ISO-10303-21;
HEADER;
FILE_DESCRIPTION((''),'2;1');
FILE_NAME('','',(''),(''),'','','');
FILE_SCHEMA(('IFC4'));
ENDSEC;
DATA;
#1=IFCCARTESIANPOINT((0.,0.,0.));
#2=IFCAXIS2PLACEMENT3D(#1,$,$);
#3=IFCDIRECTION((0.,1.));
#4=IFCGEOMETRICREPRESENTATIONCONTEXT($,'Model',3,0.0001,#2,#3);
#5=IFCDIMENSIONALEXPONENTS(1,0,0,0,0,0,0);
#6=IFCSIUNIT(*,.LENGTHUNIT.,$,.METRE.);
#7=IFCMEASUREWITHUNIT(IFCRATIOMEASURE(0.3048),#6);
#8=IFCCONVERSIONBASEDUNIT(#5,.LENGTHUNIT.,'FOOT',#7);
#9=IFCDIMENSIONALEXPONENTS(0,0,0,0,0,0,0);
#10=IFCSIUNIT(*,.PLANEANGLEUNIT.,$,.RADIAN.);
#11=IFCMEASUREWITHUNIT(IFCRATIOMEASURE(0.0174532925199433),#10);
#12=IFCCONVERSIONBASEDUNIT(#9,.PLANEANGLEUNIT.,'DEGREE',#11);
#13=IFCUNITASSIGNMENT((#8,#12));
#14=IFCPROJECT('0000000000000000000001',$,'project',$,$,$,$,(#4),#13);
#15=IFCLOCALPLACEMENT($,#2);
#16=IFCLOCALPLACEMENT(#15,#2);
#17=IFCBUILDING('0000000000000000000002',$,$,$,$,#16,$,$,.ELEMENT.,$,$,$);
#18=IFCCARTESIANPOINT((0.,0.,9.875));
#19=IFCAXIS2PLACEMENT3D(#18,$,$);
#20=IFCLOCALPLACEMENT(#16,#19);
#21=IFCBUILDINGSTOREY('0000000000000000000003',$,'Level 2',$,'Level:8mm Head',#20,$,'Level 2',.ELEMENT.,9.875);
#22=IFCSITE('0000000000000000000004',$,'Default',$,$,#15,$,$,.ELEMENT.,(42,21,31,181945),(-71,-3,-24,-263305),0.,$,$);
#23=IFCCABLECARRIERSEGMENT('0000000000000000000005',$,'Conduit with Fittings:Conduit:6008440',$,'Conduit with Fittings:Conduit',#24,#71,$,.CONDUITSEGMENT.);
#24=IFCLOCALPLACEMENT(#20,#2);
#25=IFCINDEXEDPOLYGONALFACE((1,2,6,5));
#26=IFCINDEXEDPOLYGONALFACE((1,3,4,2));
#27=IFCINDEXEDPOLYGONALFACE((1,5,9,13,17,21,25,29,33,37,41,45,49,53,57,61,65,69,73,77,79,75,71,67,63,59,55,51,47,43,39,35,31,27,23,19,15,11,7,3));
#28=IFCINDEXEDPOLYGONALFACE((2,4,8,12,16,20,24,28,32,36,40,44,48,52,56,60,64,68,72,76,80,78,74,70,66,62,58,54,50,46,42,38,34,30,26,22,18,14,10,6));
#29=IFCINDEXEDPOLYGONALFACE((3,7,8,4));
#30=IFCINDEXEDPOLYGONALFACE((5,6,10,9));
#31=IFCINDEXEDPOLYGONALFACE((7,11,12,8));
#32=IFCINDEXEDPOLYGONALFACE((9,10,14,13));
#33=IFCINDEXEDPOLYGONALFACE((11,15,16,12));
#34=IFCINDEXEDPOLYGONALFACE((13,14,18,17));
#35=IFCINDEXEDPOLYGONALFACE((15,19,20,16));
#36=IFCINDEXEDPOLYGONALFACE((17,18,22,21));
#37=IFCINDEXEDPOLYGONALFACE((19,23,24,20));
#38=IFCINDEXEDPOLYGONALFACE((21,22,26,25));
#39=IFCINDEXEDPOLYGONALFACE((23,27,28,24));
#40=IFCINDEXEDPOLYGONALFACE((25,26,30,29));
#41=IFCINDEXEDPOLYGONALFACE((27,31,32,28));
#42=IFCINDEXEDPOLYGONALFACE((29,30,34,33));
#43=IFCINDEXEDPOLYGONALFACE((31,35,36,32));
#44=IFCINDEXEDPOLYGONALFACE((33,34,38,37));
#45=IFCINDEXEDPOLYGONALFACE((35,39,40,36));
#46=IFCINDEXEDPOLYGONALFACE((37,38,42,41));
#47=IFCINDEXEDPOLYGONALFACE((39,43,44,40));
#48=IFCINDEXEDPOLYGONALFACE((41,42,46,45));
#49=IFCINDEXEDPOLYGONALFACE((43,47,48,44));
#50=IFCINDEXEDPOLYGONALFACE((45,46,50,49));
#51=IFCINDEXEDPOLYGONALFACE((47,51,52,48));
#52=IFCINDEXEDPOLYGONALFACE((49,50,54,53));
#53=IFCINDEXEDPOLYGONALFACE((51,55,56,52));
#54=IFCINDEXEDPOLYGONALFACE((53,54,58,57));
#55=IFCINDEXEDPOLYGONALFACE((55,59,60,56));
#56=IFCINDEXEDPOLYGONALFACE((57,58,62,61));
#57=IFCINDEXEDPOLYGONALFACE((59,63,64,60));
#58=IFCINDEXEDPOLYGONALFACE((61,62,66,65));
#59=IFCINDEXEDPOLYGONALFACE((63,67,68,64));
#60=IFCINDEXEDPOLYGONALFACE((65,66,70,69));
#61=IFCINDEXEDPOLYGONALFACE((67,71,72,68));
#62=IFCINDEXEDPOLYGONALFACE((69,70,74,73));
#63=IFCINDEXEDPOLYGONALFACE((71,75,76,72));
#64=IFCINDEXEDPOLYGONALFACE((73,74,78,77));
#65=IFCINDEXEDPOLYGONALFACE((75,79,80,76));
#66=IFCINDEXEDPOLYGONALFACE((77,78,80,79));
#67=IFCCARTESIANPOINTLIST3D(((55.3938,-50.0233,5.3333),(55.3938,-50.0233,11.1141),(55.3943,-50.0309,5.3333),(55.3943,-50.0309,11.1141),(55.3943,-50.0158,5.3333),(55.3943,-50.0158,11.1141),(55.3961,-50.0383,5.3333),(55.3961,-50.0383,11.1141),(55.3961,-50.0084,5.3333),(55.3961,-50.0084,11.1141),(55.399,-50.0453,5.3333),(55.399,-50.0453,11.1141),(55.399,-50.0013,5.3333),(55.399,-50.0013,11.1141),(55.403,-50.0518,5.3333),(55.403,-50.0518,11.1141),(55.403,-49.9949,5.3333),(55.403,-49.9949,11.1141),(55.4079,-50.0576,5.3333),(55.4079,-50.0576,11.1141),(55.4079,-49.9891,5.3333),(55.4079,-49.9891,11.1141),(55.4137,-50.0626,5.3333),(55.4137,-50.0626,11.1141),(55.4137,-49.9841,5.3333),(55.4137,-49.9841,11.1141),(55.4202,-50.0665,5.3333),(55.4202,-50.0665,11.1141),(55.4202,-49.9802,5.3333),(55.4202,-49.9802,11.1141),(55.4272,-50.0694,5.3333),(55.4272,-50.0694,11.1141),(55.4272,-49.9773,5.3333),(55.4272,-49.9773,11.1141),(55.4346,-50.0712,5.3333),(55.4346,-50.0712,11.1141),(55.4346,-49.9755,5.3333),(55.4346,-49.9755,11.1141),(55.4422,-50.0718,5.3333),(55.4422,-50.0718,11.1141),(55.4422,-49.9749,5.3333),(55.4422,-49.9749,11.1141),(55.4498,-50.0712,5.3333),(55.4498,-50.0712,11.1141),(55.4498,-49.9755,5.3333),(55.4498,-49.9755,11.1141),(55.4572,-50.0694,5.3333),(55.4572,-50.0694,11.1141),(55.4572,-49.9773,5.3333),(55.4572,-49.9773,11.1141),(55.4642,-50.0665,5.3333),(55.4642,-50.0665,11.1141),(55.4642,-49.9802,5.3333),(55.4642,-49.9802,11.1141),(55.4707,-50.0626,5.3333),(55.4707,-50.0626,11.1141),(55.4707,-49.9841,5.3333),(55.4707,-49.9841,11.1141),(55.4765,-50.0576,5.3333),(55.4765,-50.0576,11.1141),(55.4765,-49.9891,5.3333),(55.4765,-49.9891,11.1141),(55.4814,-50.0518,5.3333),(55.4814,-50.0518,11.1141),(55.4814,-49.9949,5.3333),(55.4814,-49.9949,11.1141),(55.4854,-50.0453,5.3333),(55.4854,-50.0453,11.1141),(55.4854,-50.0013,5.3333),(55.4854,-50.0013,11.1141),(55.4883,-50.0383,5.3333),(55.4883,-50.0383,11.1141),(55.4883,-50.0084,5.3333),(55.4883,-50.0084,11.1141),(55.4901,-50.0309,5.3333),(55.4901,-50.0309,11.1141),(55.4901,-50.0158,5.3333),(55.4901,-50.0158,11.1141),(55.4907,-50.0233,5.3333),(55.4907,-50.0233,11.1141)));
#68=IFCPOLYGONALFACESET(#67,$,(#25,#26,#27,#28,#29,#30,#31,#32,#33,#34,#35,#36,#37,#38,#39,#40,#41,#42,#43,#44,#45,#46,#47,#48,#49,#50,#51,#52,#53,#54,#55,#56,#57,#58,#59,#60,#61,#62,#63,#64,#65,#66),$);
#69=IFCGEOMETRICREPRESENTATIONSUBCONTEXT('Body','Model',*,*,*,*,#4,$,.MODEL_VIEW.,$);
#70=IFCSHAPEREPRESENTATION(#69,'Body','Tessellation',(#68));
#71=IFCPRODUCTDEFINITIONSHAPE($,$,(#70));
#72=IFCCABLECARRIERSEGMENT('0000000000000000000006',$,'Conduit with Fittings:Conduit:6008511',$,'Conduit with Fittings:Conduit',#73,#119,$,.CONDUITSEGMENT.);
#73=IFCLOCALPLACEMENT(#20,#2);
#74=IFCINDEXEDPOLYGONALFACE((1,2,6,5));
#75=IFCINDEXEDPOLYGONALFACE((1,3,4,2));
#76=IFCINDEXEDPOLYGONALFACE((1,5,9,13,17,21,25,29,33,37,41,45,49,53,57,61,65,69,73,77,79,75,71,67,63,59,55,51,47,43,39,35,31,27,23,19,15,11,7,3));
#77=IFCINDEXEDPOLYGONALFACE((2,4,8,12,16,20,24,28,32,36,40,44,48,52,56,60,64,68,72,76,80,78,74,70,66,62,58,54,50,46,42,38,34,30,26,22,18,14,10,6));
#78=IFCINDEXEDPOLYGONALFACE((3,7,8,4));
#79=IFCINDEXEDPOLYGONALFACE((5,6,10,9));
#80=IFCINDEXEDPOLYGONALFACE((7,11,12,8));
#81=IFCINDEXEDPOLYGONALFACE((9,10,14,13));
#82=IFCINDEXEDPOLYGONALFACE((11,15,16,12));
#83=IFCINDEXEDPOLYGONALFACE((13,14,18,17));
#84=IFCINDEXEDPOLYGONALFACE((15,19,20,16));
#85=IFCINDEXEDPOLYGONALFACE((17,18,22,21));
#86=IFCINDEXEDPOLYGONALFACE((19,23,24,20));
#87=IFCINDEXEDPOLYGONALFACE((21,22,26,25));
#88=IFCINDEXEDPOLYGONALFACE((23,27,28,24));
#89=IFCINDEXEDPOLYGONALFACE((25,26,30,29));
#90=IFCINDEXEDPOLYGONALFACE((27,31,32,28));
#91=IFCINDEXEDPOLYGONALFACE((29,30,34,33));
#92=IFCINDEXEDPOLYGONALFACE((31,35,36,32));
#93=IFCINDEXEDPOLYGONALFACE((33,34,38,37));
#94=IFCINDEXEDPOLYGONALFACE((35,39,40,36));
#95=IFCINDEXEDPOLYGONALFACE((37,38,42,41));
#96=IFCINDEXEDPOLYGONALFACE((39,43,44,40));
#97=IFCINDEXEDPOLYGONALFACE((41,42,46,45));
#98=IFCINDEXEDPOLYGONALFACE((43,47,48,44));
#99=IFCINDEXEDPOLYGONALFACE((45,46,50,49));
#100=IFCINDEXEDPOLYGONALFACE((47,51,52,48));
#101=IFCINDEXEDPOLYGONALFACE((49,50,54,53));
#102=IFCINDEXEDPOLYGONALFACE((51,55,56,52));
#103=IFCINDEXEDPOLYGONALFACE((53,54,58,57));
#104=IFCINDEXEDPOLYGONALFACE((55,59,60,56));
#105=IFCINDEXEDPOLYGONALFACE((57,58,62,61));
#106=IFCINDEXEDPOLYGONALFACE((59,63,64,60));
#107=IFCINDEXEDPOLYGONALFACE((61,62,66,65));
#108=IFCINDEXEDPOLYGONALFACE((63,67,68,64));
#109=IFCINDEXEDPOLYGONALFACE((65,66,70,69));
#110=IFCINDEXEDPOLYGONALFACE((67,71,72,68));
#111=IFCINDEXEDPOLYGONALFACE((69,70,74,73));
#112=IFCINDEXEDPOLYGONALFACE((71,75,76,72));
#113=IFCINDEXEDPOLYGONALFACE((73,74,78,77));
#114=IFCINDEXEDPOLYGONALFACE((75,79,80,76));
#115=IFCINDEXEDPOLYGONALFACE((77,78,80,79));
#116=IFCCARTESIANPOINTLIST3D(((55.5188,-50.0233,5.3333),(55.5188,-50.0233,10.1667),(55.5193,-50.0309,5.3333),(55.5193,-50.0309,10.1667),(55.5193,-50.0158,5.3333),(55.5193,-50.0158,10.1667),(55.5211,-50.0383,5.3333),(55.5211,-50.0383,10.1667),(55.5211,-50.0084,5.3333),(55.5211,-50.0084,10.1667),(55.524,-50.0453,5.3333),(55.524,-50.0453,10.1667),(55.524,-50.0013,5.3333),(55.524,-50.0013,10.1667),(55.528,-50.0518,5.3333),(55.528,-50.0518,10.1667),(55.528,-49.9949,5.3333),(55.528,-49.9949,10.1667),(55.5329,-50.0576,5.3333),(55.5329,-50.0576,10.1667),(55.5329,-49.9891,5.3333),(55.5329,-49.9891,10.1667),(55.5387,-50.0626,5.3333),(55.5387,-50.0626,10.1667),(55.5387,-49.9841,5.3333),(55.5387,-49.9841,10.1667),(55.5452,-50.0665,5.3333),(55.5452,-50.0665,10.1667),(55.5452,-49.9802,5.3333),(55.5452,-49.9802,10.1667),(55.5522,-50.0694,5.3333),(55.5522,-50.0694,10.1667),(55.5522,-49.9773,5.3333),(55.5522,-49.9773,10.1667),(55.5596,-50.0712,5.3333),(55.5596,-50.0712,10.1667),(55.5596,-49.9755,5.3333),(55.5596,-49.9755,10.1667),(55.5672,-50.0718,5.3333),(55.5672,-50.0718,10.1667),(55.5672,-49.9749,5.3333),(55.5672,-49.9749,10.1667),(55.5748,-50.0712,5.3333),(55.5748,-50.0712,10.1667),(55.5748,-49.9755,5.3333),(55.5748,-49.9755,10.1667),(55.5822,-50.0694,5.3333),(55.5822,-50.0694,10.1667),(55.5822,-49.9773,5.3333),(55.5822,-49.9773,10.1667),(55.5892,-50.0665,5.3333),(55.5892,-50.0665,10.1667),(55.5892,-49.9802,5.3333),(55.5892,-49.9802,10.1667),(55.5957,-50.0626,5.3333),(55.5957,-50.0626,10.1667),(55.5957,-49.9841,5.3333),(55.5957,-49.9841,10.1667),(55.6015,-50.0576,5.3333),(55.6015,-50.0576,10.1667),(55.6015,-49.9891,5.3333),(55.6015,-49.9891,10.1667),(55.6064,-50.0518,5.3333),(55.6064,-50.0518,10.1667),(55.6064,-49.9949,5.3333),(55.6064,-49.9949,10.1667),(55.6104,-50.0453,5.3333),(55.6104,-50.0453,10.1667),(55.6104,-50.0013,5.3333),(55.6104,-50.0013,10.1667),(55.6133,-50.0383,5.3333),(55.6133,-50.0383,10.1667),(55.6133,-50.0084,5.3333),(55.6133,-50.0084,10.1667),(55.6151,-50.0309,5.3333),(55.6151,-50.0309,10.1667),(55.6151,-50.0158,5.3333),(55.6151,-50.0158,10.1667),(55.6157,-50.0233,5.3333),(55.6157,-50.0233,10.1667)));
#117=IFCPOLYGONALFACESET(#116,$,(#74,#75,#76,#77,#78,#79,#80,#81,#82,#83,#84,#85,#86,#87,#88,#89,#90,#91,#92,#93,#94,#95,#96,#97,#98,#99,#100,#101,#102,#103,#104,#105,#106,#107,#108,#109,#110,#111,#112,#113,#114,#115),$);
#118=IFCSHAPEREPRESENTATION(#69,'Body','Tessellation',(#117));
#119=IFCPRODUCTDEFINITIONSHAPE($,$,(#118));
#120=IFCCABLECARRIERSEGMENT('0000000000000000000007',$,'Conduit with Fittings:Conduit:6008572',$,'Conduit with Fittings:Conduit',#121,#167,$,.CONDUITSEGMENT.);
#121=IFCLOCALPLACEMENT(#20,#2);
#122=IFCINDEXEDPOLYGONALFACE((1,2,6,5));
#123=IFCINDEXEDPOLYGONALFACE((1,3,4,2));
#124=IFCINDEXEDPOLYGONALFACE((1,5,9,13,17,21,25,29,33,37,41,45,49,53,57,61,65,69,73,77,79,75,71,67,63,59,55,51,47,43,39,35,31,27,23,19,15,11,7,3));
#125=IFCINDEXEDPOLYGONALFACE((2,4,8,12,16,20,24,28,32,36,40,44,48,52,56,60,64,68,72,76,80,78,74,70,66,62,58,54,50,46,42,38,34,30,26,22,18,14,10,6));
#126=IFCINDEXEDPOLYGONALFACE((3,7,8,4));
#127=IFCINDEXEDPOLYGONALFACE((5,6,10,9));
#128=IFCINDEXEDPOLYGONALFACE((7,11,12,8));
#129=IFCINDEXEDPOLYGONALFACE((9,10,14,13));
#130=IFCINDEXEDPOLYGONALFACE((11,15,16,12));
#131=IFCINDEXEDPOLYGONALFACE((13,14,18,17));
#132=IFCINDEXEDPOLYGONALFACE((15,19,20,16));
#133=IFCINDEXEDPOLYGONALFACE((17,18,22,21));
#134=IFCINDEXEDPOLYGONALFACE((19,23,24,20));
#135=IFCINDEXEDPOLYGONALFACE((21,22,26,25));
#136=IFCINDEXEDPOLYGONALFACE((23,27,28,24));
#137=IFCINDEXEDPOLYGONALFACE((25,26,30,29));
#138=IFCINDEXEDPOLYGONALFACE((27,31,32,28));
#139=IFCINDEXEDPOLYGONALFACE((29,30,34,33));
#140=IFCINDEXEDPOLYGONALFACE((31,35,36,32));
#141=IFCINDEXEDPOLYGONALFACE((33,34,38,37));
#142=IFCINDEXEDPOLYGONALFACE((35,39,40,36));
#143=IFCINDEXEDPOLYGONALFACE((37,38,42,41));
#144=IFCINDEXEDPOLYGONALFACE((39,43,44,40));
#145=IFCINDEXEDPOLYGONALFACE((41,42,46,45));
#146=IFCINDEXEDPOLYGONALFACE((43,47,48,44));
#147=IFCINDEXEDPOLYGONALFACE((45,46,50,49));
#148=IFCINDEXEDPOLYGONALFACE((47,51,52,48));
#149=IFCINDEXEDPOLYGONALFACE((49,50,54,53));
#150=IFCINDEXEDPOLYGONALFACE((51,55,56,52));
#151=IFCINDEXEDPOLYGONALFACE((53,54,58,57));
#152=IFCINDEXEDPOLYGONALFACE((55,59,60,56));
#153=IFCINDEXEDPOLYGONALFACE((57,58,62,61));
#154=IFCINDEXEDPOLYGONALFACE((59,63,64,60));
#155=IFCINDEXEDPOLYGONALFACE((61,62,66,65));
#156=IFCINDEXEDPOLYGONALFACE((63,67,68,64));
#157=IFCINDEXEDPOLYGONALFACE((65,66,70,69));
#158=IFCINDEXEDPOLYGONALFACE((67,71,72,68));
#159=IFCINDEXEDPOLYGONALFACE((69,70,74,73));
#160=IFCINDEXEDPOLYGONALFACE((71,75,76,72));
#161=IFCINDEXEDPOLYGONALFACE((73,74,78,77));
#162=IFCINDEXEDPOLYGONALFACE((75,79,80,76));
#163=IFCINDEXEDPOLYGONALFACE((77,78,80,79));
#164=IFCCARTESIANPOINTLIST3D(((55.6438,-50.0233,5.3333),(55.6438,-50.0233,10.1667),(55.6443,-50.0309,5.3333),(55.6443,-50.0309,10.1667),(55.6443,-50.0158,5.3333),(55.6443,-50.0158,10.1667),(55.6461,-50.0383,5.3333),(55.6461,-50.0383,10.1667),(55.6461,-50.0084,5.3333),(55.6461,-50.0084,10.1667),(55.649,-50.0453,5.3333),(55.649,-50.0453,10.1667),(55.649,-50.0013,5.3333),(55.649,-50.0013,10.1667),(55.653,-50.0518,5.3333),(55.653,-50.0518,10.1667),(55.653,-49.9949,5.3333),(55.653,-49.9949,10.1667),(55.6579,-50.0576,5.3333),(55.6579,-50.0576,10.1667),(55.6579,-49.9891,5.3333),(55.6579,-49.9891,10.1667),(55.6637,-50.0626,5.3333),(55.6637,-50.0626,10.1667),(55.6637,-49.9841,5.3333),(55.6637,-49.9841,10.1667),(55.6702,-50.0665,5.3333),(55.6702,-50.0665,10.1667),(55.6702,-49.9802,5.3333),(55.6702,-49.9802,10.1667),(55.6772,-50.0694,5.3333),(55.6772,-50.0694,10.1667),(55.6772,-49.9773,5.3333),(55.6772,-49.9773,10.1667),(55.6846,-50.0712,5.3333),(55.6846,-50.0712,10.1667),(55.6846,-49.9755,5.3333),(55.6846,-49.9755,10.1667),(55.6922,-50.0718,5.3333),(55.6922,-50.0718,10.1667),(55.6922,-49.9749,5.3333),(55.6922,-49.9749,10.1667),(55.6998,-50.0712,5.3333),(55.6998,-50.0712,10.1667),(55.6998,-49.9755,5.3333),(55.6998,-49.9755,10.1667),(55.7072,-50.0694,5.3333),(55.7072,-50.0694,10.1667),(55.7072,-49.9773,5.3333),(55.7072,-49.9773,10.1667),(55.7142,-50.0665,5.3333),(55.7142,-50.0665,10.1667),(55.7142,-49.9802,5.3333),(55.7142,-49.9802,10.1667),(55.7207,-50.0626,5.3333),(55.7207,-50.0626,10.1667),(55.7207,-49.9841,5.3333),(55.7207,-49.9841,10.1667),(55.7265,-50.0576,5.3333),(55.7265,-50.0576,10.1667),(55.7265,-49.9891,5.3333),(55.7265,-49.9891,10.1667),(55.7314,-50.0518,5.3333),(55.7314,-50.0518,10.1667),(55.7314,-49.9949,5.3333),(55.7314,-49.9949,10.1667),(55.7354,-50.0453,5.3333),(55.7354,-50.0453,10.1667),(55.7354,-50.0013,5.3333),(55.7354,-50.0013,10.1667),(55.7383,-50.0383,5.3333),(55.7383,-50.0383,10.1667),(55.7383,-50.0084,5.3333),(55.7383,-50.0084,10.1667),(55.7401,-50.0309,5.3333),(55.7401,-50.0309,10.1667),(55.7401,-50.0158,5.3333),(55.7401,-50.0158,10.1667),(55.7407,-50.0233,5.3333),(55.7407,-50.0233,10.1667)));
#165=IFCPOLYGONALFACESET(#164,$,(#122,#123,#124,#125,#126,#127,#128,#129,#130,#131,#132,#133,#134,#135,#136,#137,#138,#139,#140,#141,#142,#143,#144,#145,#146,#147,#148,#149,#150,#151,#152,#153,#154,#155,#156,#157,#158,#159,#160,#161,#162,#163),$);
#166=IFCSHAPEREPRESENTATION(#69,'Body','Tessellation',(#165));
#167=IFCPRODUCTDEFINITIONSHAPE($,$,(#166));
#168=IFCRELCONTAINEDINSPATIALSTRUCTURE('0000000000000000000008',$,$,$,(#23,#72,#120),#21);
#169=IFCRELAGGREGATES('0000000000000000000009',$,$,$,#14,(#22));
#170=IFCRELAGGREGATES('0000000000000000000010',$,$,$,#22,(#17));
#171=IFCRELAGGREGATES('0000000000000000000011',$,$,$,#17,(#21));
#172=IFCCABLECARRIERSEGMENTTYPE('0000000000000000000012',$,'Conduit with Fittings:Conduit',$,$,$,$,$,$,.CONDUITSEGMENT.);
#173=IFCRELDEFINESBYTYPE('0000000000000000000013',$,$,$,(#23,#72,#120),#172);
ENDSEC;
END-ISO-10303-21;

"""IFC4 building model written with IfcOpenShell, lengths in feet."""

from ifc_helpers import new_model, entity, si_unit, converted_unit, direction, frame, origin, place, context, subcontext, project, spatial, indexed_curve, outline, extrude, type_object, element, save


model = new_model("IFC4")

# Units and contexts
model_context = context("Model", 3, precision=0.0001, world=origin(), true_north=direction((0.0, 1.0)))
body_context = subcontext(model_context, "Body", "Model", "MODEL_VIEW")
ifc_project = project(units=[converted_unit("LENGTHUNIT", "FOOT", entity("IfcRatioMeasure", 0.3048), si_unit("LENGTHUNIT", "METRE"), dimensions=[1, 0, 0, 0, 0, 0, 0]), converted_unit("PLANEANGLEUNIT", "DEGREE", entity("IfcRatioMeasure", 0.0174532925199433), si_unit("PLANEANGLEUNIT", "RADIAN"), dimensions=[0, 0, 0, 0, 0, 0, 0])], contexts=[model_context])

# Site, building, storey
site_placement = place(None, origin())
site = spatial("IfcSite", under=ifc_project, at=site_placement, Name="Default", CompositionType="ELEMENT", RefLatitude=(42, 21, 31, 181945), RefLongitude=(-71, -3, -24, -263305), RefElevation=0.0)
building_placement = place(site_placement, origin())
building = spatial("IfcBuilding", under=site, at=building_placement, CompositionType="ELEMENT")
storey_placement = place(building_placement, frame((0.0, 0.0, 9.875)))
storey = spatial("IfcBuildingStorey", under=building, at=storey_placement, Name="Level 2", ObjectType="Level:8mm Head", LongName="Level 2", CompositionType="ELEMENT", Elevation=9.875)

# Cable carrier segments
cable_carrier_segment_type = type_object("IfcCableCarrierSegmentType", Name="Conduit with Fittings:Conduit", PredefinedType="CONDUITSEGMENT")
cable_carrier_segment_1_placement = place(storey_placement, origin())
element("IfcCableCarrierSegment", 1, at=cable_carrier_segment_1_placement, inside=storey, type_object=cable_carrier_segment_type, Name="Conduit with Fittings:Conduit:6008440", ObjectType="Conduit with Fittings:Conduit", PredefinedType="CONDUITSEGMENT", context=body_context, shape_type="SweptSolid", body=[
    extrude(outline(indexed_curve([(0.0485, 0.0), (0.0479, 0.0076), (0.0461, 0.015), (0.0432, 0.022), (0.0392, 0.0285), (0.0343, 0.0343), (0.0285, 0.0392), (0.022, 0.0432), (0.015, 0.0461), (0.0076, 0.0479), (0.0, 0.0485), (-0.0076, 0.0479), (-0.015, 0.0461), (-0.022, 0.0432), (-0.0285, 0.0392), (-0.0343, 0.0343), (-0.0392, 0.0285), (-0.0432, 0.022), (-0.0461, 0.015), (-0.0479, 0.0076), (-0.0485, 0.0), (-0.0479, -0.0076), (-0.0461, -0.015), (-0.0432, -0.022), (-0.0392, -0.0285), (-0.0343, -0.0343), (-0.0285, -0.0392), (-0.022, -0.0432), (-0.015, -0.0461), (-0.0076, -0.0479), (0.0, -0.0485), (0.0076, -0.0479), (0.015, -0.0461), (0.022, -0.0432), (0.0285, -0.0392), (0.0343, -0.0343), (0.0392, -0.0285), (0.0432, -0.022), (0.0461, -0.015), (0.0479, -0.0076), (0.0485, 0.0)], self_intersect=False)), frame((55.4422, -50.0233, 5.3333), z_axis=(0.0, 0.0, 1.0), x_axis=(-1.0, 0.0, 0.0)), (0.0, 0.0, 1.0), 5.7808),
])
cable_carrier_segment_2_placement = place(storey_placement, origin())
element("IfcCableCarrierSegment", 2, at=cable_carrier_segment_2_placement, inside=storey, type_object=cable_carrier_segment_type, Name="Conduit with Fittings:Conduit:6008511", ObjectType="Conduit with Fittings:Conduit", PredefinedType="CONDUITSEGMENT", context=body_context, shape_type="SweptSolid", body=[
    extrude(outline(indexed_curve([(0.0485, 0.0), (0.0479, 0.0076), (0.0461, 0.015), (0.0432, 0.022), (0.0392, 0.0285), (0.0343, 0.0343), (0.0285, 0.0392), (0.022, 0.0432), (0.015, 0.0461), (0.0076, 0.0479), (0.0, 0.0485), (-0.0076, 0.0479), (-0.015, 0.0461), (-0.022, 0.0432), (-0.0285, 0.0392), (-0.0343, 0.0343), (-0.0392, 0.0285), (-0.0432, 0.022), (-0.0461, 0.015), (-0.0479, 0.0076), (-0.0485, 0.0), (-0.0479, -0.0076), (-0.0461, -0.015), (-0.0432, -0.022), (-0.0392, -0.0285), (-0.0343, -0.0343), (-0.0285, -0.0392), (-0.022, -0.0432), (-0.015, -0.0461), (-0.0076, -0.0479), (0.0, -0.0485), (0.0076, -0.0479), (0.015, -0.0461), (0.022, -0.0432), (0.0285, -0.0392), (0.0343, -0.0343), (0.0392, -0.0285), (0.0432, -0.022), (0.0461, -0.015), (0.0479, -0.0076), (0.0485, 0.0)], self_intersect=False)), frame((55.5672, -50.0233, 5.3333), z_axis=(0.0, 0.0, 1.0), x_axis=(-1.0, 0.0, 0.0)), (0.0, 0.0, 1.0), 4.8333),
])
cable_carrier_segment_3_placement = place(storey_placement, origin())
element("IfcCableCarrierSegment", 3, at=cable_carrier_segment_3_placement, inside=storey, type_object=cable_carrier_segment_type, Name="Conduit with Fittings:Conduit:6008572", ObjectType="Conduit with Fittings:Conduit", PredefinedType="CONDUITSEGMENT", context=body_context, shape_type="SweptSolid", body=[
    extrude(outline(indexed_curve([(0.0485, 0.0), (0.0479, 0.0076), (0.0461, 0.015), (0.0432, 0.022), (0.0392, 0.0285), (0.0343, 0.0343), (0.0285, 0.0392), (0.022, 0.0432), (0.015, 0.0461), (0.0076, 0.0479), (0.0, 0.0485), (-0.0076, 0.0479), (-0.015, 0.0461), (-0.022, 0.0432), (-0.0285, 0.0392), (-0.0343, 0.0343), (-0.0392, 0.0285), (-0.0432, 0.022), (-0.0461, 0.015), (-0.0479, 0.0076), (-0.0485, 0.0), (-0.0479, -0.0076), (-0.0461, -0.015), (-0.0432, -0.022), (-0.0392, -0.0285), (-0.0343, -0.0343), (-0.0285, -0.0392), (-0.022, -0.0432), (-0.015, -0.0461), (-0.0076, -0.0479), (0.0, -0.0485), (0.0076, -0.0479), (0.015, -0.0461), (0.022, -0.0432), (0.0285, -0.0392), (0.0343, -0.0343), (0.0392, -0.0285), (0.0432, -0.022), (0.0461, -0.015), (0.0479, -0.0076), (0.0485, 0.0)], self_intersect=False)), frame((55.6922, -50.0233, 5.3333), z_axis=(0.0, 0.0, 1.0), x_axis=(-1.0, 0.0, 0.0)), (0.0, 0.0, 1.0), 4.8333),
])

save(model, "model.ifc")
